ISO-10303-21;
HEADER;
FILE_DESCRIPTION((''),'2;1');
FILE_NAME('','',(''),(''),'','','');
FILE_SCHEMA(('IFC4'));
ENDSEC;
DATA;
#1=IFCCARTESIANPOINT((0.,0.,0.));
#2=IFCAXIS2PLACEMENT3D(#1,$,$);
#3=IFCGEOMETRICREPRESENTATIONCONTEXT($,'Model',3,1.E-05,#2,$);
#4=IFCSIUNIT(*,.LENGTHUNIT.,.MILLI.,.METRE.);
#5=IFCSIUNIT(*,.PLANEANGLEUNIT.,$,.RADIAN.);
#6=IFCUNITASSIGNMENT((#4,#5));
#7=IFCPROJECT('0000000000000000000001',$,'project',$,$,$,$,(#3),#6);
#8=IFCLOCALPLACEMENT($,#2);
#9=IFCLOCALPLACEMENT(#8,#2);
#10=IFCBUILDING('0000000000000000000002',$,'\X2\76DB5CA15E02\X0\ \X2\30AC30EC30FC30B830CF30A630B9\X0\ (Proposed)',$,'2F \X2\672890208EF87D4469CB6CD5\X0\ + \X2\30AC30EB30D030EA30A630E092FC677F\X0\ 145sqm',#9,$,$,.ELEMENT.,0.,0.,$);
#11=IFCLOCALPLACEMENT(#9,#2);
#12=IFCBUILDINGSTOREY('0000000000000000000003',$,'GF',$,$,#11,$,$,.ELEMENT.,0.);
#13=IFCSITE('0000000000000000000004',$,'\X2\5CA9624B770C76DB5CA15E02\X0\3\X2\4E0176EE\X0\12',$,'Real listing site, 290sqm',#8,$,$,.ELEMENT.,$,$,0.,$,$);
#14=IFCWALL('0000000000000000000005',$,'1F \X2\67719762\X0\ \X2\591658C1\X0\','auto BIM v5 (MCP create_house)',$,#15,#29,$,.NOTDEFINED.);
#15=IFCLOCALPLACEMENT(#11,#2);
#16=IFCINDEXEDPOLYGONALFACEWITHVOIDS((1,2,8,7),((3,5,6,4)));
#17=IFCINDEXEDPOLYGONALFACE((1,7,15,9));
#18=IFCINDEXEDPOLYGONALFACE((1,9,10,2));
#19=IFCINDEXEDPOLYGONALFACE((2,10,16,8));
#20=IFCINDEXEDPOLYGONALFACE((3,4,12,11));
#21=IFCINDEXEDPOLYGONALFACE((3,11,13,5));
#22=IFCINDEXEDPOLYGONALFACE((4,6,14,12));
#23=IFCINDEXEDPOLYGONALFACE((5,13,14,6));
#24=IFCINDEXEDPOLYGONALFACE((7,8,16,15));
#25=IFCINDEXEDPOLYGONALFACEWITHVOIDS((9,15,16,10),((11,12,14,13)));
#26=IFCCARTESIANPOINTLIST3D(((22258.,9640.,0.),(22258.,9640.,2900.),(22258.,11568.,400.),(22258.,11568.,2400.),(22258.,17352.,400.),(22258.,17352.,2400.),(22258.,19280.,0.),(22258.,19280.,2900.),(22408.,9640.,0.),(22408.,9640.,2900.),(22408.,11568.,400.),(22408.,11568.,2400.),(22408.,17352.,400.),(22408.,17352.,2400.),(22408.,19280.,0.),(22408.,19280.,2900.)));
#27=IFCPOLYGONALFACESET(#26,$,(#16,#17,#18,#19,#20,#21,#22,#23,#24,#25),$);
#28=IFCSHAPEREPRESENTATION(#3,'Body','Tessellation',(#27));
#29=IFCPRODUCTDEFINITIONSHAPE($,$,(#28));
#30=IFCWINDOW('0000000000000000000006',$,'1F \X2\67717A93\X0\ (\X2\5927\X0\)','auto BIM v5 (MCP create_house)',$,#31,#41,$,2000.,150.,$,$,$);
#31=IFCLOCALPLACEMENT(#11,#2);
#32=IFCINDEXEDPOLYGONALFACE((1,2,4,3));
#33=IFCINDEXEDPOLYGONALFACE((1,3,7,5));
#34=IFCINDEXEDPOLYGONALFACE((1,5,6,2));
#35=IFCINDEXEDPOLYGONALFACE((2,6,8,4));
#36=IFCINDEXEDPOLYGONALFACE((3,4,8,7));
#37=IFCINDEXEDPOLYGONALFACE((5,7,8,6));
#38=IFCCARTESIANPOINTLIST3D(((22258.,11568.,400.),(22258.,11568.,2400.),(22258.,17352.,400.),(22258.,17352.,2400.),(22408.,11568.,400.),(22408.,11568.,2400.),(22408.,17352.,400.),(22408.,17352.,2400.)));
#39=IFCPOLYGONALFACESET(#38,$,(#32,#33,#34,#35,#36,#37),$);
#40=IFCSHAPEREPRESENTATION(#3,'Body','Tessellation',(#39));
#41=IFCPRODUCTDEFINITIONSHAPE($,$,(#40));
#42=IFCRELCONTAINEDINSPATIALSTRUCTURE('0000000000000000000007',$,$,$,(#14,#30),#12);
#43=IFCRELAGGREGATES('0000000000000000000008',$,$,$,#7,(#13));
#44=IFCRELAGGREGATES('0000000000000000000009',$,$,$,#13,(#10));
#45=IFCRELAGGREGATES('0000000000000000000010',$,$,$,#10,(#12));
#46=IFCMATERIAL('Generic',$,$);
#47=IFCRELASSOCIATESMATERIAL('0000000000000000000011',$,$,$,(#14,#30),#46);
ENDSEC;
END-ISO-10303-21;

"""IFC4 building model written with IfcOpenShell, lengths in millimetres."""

from ifc_helpers import new_model, si_unit, frame, frame_2d, origin, place, context, project, spatial, rectangle, extrude, material, element, fill, save


model = new_model("IFC4")

# Units and contexts
model_context = context("Model", 3, precision=1e-05, world=origin())
ifc_project = project(units=[si_unit("LENGTHUNIT", "METRE", prefix="MILLI"), si_unit("PLANEANGLEUNIT", "RADIAN")], contexts=[model_context])

# Site, building, storey
site_placement = place(None, origin())
site = spatial("IfcSite", under=ifc_project, at=site_placement, Name="岩手県盛岡市3丁目12", ObjectType="Real listing site, 290sqm", CompositionType="ELEMENT", RefElevation=0.0)
building_placement = place(site_placement, origin())
building = spatial("IfcBuilding", under=site, at=building_placement, Name="盛岡市 ガレージハウス (Proposed)", ObjectType="2F 木造軸組構法 + ガルバリウム鋼板 145sqm", CompositionType="ELEMENT", ElevationOfRefHeight=0.0, ElevationOfTerrain=0.0)
storey_placement = place(building_placement, origin())
storey = spatial("IfcBuildingStorey", under=building, at=storey_placement, Name="GF", CompositionType="ELEMENT", Elevation=0.0)

# Shared definitions
ifc_material = material(Name="Generic")

# Wall, opening, window
wall_1_placement = place(storey_placement, frame((11129.0, 4820.0, 0.0)))
wall_1 = element("IfcWall", 1, at=wall_1_placement, inside=storey, material=ifc_material, Name="1F 東面 外壁", Description="auto BIM v5 (MCP create_house)", PredefinedType="NOTDEFINED", context=model_context, shape_type="SweptSolid", body=[
    extrude(rectangle(XDim=150.0, YDim=9640.0, at=frame_2d((75.0, 4820.0))), frame((11129.0, 4820.0, 0.0)), (0.0, 0.0, 1.0), 2900.0),
])
opening_1_placement = place(storey_placement, frame((11129.0, 5784.0, 200.0)))
opening_1 = element("IfcOpeningElement", 2, at=opening_1_placement, cuts=wall_1, PredefinedType="NOTDEFINED", context=model_context, shape_type="SweptSolid", body=[
    extrude(rectangle(XDim=150.0, YDim=5784.0, at=frame_2d((75.0, 2892.0))), frame((11129.0, 5784.0, 200.0)), (0.0, 0.0, 1.0), 2000.0),
])
window_1_placement = place(storey_placement, frame((11129.0, 5784.0, 200.0)))
window_1 = element("IfcWindow", 3, at=window_1_placement, inside=storey, material=ifc_material, Name="1F 東窓 (大)", Description="auto BIM v5 (MCP create_house)", OverallHeight=2000.0, OverallWidth=150.0, context=model_context, shape_type="SweptSolid", body=[
    extrude(rectangle(XDim=150.0, YDim=5784.0, at=frame_2d((75.0, 2892.0))), frame((11129.0, 5784.0, 200.0)), (0.0, 0.0, 1.0), 2000.0),
])
fill(opening_1, window_1)

save(model, "model.ifc")
